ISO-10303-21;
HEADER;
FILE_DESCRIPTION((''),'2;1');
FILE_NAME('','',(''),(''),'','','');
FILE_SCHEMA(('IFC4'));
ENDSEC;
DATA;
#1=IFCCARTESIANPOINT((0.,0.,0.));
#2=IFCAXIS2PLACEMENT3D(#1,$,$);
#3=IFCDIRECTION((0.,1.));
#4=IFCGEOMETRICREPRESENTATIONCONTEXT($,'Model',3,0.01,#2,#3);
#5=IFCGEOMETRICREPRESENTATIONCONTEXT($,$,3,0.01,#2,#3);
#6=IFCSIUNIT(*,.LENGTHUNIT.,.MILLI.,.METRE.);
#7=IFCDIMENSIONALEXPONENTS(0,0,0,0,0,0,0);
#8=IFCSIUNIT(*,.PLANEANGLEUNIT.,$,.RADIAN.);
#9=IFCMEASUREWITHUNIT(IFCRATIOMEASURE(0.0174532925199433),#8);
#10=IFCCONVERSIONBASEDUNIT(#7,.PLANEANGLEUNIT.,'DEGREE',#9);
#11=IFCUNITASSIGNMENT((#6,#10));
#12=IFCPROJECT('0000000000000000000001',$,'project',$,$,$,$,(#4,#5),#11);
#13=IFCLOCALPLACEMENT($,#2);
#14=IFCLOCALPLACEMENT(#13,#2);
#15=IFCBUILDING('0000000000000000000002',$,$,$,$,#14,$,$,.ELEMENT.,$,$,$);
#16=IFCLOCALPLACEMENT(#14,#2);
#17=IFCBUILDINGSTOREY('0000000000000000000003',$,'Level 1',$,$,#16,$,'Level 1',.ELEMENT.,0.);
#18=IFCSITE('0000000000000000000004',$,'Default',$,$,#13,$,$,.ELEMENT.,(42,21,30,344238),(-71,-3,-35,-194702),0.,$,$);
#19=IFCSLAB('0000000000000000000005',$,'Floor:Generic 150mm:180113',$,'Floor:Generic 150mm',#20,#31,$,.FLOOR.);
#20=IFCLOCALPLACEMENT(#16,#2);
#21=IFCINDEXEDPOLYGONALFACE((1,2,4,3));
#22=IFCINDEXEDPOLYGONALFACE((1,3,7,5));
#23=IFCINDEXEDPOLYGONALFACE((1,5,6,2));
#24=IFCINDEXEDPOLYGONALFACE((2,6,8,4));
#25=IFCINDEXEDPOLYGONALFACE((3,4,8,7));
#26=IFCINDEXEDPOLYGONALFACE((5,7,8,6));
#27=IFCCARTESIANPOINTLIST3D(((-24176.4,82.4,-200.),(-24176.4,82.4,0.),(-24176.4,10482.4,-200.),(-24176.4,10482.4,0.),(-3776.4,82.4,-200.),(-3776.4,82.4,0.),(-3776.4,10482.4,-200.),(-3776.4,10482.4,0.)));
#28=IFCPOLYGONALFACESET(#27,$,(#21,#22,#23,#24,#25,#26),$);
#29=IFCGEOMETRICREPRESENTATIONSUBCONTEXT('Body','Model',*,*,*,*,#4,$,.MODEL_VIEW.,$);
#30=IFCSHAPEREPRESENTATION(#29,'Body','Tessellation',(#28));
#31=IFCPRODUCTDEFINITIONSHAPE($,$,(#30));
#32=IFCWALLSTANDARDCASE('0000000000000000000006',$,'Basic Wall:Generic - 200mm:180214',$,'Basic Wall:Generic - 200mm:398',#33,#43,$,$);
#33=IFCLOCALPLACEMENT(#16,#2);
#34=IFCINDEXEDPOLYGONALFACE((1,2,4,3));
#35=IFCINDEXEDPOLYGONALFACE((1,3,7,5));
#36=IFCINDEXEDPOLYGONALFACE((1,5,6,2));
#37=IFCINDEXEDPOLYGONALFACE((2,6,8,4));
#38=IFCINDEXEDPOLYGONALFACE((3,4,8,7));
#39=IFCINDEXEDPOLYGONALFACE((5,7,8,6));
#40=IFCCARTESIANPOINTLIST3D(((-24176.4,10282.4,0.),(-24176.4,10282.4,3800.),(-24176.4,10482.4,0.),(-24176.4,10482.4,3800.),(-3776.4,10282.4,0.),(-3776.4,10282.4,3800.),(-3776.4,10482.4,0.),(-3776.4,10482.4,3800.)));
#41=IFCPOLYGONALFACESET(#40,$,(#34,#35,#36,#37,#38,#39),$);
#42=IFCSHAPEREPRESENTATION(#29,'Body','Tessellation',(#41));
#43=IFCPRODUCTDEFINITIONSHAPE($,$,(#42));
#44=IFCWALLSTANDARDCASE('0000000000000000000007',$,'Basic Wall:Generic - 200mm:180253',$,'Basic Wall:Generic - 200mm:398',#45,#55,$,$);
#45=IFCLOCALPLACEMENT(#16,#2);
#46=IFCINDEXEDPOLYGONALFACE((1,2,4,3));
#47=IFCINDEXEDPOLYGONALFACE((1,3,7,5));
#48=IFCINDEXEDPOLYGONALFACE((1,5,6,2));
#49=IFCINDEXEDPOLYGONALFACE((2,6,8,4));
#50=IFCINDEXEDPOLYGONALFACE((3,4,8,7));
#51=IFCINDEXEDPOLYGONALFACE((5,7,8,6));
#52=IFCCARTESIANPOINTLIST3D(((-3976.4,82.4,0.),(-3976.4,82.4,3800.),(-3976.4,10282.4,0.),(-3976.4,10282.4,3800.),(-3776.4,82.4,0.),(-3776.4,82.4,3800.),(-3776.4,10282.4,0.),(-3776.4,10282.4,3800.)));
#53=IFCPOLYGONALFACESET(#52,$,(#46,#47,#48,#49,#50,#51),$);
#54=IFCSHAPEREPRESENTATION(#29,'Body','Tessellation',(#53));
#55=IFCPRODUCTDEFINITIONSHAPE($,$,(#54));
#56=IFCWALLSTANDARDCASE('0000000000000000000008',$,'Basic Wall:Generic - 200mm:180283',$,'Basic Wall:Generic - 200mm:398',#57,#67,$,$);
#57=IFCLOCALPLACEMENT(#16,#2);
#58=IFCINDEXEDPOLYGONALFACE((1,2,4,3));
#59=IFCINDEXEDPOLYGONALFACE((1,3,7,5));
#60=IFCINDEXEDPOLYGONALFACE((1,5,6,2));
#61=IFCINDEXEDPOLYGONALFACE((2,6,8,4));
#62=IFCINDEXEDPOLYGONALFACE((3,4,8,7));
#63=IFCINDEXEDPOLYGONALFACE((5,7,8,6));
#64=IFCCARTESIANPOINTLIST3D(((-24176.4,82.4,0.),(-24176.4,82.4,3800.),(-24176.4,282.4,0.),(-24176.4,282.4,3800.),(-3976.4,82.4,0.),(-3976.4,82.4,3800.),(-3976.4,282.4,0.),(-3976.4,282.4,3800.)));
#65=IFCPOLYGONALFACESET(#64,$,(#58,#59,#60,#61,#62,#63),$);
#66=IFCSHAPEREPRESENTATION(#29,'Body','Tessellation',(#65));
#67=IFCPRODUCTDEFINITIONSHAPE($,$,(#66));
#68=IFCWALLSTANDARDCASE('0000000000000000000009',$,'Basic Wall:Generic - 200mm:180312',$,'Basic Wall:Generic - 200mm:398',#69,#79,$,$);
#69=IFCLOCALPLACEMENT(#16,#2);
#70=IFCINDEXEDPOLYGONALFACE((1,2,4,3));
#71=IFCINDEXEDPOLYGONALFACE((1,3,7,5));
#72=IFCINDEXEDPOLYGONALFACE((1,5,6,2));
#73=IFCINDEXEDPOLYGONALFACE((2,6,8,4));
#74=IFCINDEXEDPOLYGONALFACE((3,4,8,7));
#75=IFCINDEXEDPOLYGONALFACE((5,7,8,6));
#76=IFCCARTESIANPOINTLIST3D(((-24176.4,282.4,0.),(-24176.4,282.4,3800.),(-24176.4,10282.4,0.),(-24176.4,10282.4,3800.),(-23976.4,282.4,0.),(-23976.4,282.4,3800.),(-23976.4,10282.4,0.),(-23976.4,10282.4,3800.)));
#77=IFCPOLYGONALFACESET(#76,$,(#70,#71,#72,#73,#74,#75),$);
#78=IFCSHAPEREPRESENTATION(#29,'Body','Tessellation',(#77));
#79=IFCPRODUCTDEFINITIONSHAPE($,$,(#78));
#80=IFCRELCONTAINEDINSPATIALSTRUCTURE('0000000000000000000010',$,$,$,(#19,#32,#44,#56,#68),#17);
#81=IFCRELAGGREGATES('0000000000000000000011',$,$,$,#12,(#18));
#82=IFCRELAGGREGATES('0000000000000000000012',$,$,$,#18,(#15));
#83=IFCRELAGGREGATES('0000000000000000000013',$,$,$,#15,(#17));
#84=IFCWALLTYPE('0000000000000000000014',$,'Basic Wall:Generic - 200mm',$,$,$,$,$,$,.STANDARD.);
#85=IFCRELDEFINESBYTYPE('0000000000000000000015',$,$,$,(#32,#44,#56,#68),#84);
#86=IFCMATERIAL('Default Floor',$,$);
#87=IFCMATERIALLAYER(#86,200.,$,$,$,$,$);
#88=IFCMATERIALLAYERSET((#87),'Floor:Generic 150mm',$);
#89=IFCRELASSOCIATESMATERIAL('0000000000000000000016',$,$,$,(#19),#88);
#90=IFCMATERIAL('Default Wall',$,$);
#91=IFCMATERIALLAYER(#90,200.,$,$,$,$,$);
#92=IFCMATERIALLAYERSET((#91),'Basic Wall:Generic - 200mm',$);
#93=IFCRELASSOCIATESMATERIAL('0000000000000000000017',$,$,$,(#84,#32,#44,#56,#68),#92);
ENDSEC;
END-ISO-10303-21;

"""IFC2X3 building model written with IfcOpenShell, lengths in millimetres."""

from ifc_helpers import new_model, entity, si_unit, converted_unit, direction, frame, frame_2d, origin, origin_2d_with_axis, place, context, subcontext, project, spatial, rectangle, extrude, material, layer, layer_set, layer_usage, type_object, element, save


model = new_model("IFC2X3")

# Units and contexts
model_context = context("Model", 3, precision=0.01, world=origin(), true_north=direction((0.0, 1.0)))
context_of_model = context(None, 3, precision=0.01, world=origin(), true_north=direction((0.0, 1.0)))
body_context = subcontext(model_context, "Body", "Model", "MODEL_VIEW")
ifc_project = project(units=[si_unit("LENGTHUNIT", "METRE", prefix="MILLI"), converted_unit("PLANEANGLEUNIT", "DEGREE", entity("IfcRatioMeasure", 0.0174532925199433), si_unit("PLANEANGLEUNIT", "RADIAN"), dimensions=[0, 0, 0, 0, 0, 0, 0])], contexts=[model_context, context_of_model])

# Site, building, storey
site_placement = place(None, origin())
site = spatial("IfcSite", under=ifc_project, at=site_placement, Name="Default", CompositionType="ELEMENT", RefLatitude=(42, 21, 30, 344238), RefLongitude=(-71, -3, -35, -194702), RefElevation=0.0)
building_placement = place(site_placement, origin())
building = spatial("IfcBuilding", under=site, at=building_placement, CompositionType="ELEMENT")
storey_placement = place(building_placement, origin())
storey = spatial("IfcBuildingStorey", under=building, at=storey_placement, Name="Level 1", LongName="Level 1", CompositionType="ELEMENT", Elevation=0.0)

# Slab
ifc_material_1 = material(Name="Default Floor")
ifc_layer_1 = layer(ifc_material_1, 200.0)
ifc_layer_set_1 = layer_set([ifc_layer_1], Name="Floor:Generic 150mm")
ifc_layer_usage_1 = layer_usage(ifc_layer_set_1, "AXIS3", "POSITIVE", 0.0)
slab_placement = place(storey_placement, origin())
element("IfcSlab", 1, at=slab_placement, inside=storey, material=ifc_layer_usage_1, Name="Floor:Generic 150mm:180113", ObjectType="Floor:Generic 150mm", PredefinedType="FLOOR", context=body_context, shape_type="SweptSolid", body=[
    extrude(rectangle(XDim=10400.0, YDim=20400.0, at=origin_2d_with_axis()), frame((-13976.4, 5282.4, 0.0), z_axis=(0.0, 0.0, -1.0), x_axis=(0.0, 1.0, 0.0)), (0.0, 0.0, 1.0), 200.0),
])

# Walls
ifc_material_2 = material(Name="Default Wall")
ifc_layer_2 = layer(ifc_material_2, 200.0)
ifc_layer_set_2 = layer_set([ifc_layer_2], Name="Basic Wall:Generic - 200mm")
ifc_layer_usage_2 = layer_usage(ifc_layer_set_2, "AXIS2", "NEGATIVE", 100.0)
wall_type = type_object("IfcWallType", Name="Basic Wall:Generic - 200mm", PredefinedType="STANDARD", material=ifc_layer_set_2)
wall_1_placement = place(storey_placement, frame((-24176.4, 10382.4, 0.0)))
element("IfcWallStandardCase", 2, at=wall_1_placement, inside=storey, type_object=wall_type, material=ifc_layer_usage_2, Name="Basic Wall:Generic - 200mm:180214", ObjectType="Basic Wall:Generic - 200mm:398", context=body_context, shape_type="SweptSolid", body=[
    extrude(rectangle(XDim=20400.0, YDim=200.0, at=frame_2d((10200.0, 0.0), x_axis=(-1.0, 0.0))), origin(), (0.0, 0.0, 1.0), 3800.0),
])
ifc_layer_usage_3 = layer_usage(ifc_layer_set_2, "AXIS2", "NEGATIVE", 100.0)
wall_2_placement = place(storey_placement, frame((-3876.4, 10282.4, 0.0), z_axis=(0.0, 0.0, 1.0), x_axis=(0.0, -1.0, 0.0)))
element("IfcWallStandardCase", 3, at=wall_2_placement, inside=storey, type_object=wall_type, material=ifc_layer_usage_3, Name="Basic Wall:Generic - 200mm:180253", ObjectType="Basic Wall:Generic - 200mm:398", context=body_context, shape_type="SweptSolid", body=[
    extrude(rectangle(XDim=10200.0, YDim=200.0, at=frame_2d((5100.0, 0.0), x_axis=(-1.0, 0.0))), origin(), (0.0, 0.0, 1.0), 3800.0),
])
ifc_layer_usage_4 = layer_usage(ifc_layer_set_2, "AXIS2", "NEGATIVE", 100.0)
wall_3_placement = place(storey_placement, frame((-3976.4, 182.4, 0.0), z_axis=(0.0, 0.0, 1.0), x_axis=(-1.0, 0.0, 0.0)))
element("IfcWallStandardCase", 4, at=wall_3_placement, inside=storey, type_object=wall_type, material=ifc_layer_usage_4, Name="Basic Wall:Generic - 200mm:180283", ObjectType="Basic Wall:Generic - 200mm:398", context=body_context, shape_type="SweptSolid", body=[
    extrude(rectangle(XDim=20200.0, YDim=200.0, at=frame_2d((10100.0, 0.0), x_axis=(-1.0, 0.0))), origin(), (0.0, 0.0, 1.0), 3800.0),
])
ifc_layer_usage_5 = layer_usage(ifc_layer_set_2, "AXIS2", "NEGATIVE", 100.0)
wall_4_placement = place(storey_placement, frame((-24076.4, 282.4, 0.0), z_axis=(0.0, 0.0, 1.0), x_axis=(0.0, 1.0, 0.0)))
element("IfcWallStandardCase", 5, at=wall_4_placement, inside=storey, type_object=wall_type, material=ifc_layer_usage_5, Name="Basic Wall:Generic - 200mm:180312", ObjectType="Basic Wall:Generic - 200mm:398", context=body_context, shape_type="SweptSolid", body=[
    extrude(rectangle(XDim=10000.0, YDim=200.0, at=frame_2d((5000.0, 0.0), x_axis=(-1.0, 0.0))), origin(), (0.0, 0.0, 1.0), 3800.0),
])

save(model, "model.ifc")
